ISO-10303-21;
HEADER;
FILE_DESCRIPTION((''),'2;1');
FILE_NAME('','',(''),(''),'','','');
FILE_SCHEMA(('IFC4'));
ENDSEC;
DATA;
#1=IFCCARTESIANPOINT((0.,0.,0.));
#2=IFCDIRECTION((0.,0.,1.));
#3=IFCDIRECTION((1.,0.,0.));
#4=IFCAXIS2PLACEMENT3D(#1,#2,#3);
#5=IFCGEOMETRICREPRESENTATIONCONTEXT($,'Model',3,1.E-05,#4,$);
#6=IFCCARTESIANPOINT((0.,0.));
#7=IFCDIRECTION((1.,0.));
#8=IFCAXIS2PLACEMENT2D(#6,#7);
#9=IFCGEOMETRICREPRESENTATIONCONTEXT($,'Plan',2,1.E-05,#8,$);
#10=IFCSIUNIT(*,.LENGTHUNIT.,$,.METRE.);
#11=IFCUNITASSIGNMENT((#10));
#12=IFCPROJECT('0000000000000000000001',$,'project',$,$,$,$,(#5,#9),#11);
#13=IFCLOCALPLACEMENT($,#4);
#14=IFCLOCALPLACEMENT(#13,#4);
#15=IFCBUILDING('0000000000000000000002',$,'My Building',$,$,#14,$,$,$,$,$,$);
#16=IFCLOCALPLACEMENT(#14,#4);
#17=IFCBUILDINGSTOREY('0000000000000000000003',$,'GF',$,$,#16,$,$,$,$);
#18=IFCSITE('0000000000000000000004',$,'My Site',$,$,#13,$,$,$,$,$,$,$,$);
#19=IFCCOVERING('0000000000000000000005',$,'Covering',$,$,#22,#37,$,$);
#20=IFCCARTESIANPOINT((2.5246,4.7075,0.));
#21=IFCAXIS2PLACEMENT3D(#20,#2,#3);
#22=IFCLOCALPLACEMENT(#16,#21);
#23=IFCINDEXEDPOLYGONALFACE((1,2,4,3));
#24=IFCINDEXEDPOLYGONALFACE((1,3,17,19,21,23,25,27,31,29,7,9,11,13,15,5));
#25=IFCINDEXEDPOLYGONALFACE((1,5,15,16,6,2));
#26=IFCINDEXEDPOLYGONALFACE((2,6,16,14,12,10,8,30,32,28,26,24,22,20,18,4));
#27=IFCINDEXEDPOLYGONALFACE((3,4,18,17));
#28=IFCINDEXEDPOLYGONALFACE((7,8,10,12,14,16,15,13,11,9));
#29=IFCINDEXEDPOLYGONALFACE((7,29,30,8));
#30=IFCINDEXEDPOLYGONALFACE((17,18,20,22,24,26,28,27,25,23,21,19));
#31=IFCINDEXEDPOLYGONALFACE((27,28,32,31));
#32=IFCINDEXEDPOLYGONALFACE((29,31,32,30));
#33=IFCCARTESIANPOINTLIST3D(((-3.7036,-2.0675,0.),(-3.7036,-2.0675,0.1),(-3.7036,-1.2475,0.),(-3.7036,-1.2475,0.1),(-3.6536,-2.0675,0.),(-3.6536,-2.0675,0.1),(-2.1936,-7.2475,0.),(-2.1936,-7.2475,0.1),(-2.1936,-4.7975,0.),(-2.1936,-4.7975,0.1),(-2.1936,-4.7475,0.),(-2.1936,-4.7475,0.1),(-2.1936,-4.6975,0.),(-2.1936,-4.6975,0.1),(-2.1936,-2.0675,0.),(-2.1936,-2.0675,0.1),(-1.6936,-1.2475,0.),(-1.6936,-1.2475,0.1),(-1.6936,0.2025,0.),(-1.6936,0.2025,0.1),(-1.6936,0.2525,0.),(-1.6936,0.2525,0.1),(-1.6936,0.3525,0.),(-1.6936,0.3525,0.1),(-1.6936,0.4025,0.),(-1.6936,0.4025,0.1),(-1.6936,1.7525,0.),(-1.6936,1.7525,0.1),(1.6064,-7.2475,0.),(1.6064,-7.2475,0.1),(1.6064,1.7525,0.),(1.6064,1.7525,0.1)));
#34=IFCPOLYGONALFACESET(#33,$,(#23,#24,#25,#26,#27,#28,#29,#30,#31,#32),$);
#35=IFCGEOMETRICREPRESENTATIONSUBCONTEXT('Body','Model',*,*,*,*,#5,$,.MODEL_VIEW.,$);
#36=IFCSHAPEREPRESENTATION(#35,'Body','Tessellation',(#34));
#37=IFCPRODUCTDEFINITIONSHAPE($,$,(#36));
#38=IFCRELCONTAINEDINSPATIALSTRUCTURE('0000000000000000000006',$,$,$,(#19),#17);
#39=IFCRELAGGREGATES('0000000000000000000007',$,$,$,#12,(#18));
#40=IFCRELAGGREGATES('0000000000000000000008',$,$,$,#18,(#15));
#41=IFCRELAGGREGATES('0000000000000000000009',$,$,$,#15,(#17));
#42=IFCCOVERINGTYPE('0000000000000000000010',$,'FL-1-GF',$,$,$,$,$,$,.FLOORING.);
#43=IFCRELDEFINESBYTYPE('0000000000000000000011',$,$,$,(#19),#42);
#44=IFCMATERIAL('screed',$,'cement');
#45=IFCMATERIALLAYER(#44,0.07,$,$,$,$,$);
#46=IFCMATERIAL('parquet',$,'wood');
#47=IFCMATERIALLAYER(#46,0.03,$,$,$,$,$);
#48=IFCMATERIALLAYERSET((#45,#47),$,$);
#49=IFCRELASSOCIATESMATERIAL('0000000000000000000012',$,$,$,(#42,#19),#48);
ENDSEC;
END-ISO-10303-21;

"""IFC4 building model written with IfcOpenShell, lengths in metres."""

from ifc_helpers import new_model, si_unit, frame, origin_with_axes, origin_2d_with_axis, place, context, subcontext, project, spatial, line, indexed_curve, outline, extrude, material, layer, layer_set, layer_usage, type_object, element, save


model = new_model("IFC4")

# Units and contexts
model_context = context("Model", 3, precision=1e-05, world=origin_with_axes())
plan_context = context("Plan", 2, precision=1e-05, world=origin_2d_with_axis())
body_context_1 = subcontext(model_context, "Body", "Model", "MODEL_VIEW")
ifc_project = project(units=[si_unit("LENGTHUNIT", "METRE")], contexts=[model_context, plan_context])

# Site, building, storey
site_placement = place(None, origin_with_axes())
site = spatial("IfcSite", under=ifc_project, at=site_placement, Name="My Site")
building_placement = place(site_placement, origin_with_axes())
building = spatial("IfcBuilding", under=site, at=building_placement, Name="My Building")
storey_placement = place(building_placement, origin_with_axes())
storey = spatial("IfcBuildingStorey", under=building, at=storey_placement, Name="GF")

# Covering
ifc_material_1 = material(Name="screed", Category="cement")
ifc_layer_1 = layer(ifc_material_1, 0.07)
ifc_material_2 = material(Name="parquet", Category="wood")
ifc_layer_2 = layer(ifc_material_2, 0.03)
ifc_layer_set_1 = layer_set([ifc_layer_1, ifc_layer_2])
ifc_layer_usage_1 = layer_usage(ifc_layer_set_1, "AXIS3", "POSITIVE", 0.0)
covering_type = type_object("IfcCoveringType", Name="FL-1-GF", PredefinedType="FLOORING", material=ifc_layer_set_1)
covering_placement = place(storey_placement, frame((2.5246, 4.7075, 0.0), z_axis=(0.0, 0.0, 1.0), x_axis=(1.0, 0.0, 0.0)))
element("IfcCovering", 1, at=covering_placement, inside=storey, type_object=covering_type, material=ifc_layer_usage_1, Name="Covering", context=body_context_1, shape_type="SweptSolid", body=[
    extrude(outline(indexed_curve([(-2.1936, -2.0675), (-3.6536, -2.0675), (-3.7036, -2.0675), (-3.7036, -1.2475), (-1.6936, -1.2475), (-1.6936, 0.2025), (-1.6936, 0.2525), (-1.6936, 0.3525), (-1.6936, 0.4025), (-1.6936, 1.7525), (1.6064, 1.7525), (1.6064, -7.2475), (-2.1936, -7.2475), (-2.1936, -7.2475), (-2.1936, -4.7975), (-2.1936, -4.7475), (-2.1936, -4.7475), (-2.1936, -4.6975)], segments=[line(1, 2, 3, 4, 5, 6, 7, 8, 9, 10, 11, 12, 13, 14, 15, 16, 17, 18, 1)])), origin_with_axes(), (0.0, 0.0, 1.0), 0.1),
])

save(model, "model.ifc")
